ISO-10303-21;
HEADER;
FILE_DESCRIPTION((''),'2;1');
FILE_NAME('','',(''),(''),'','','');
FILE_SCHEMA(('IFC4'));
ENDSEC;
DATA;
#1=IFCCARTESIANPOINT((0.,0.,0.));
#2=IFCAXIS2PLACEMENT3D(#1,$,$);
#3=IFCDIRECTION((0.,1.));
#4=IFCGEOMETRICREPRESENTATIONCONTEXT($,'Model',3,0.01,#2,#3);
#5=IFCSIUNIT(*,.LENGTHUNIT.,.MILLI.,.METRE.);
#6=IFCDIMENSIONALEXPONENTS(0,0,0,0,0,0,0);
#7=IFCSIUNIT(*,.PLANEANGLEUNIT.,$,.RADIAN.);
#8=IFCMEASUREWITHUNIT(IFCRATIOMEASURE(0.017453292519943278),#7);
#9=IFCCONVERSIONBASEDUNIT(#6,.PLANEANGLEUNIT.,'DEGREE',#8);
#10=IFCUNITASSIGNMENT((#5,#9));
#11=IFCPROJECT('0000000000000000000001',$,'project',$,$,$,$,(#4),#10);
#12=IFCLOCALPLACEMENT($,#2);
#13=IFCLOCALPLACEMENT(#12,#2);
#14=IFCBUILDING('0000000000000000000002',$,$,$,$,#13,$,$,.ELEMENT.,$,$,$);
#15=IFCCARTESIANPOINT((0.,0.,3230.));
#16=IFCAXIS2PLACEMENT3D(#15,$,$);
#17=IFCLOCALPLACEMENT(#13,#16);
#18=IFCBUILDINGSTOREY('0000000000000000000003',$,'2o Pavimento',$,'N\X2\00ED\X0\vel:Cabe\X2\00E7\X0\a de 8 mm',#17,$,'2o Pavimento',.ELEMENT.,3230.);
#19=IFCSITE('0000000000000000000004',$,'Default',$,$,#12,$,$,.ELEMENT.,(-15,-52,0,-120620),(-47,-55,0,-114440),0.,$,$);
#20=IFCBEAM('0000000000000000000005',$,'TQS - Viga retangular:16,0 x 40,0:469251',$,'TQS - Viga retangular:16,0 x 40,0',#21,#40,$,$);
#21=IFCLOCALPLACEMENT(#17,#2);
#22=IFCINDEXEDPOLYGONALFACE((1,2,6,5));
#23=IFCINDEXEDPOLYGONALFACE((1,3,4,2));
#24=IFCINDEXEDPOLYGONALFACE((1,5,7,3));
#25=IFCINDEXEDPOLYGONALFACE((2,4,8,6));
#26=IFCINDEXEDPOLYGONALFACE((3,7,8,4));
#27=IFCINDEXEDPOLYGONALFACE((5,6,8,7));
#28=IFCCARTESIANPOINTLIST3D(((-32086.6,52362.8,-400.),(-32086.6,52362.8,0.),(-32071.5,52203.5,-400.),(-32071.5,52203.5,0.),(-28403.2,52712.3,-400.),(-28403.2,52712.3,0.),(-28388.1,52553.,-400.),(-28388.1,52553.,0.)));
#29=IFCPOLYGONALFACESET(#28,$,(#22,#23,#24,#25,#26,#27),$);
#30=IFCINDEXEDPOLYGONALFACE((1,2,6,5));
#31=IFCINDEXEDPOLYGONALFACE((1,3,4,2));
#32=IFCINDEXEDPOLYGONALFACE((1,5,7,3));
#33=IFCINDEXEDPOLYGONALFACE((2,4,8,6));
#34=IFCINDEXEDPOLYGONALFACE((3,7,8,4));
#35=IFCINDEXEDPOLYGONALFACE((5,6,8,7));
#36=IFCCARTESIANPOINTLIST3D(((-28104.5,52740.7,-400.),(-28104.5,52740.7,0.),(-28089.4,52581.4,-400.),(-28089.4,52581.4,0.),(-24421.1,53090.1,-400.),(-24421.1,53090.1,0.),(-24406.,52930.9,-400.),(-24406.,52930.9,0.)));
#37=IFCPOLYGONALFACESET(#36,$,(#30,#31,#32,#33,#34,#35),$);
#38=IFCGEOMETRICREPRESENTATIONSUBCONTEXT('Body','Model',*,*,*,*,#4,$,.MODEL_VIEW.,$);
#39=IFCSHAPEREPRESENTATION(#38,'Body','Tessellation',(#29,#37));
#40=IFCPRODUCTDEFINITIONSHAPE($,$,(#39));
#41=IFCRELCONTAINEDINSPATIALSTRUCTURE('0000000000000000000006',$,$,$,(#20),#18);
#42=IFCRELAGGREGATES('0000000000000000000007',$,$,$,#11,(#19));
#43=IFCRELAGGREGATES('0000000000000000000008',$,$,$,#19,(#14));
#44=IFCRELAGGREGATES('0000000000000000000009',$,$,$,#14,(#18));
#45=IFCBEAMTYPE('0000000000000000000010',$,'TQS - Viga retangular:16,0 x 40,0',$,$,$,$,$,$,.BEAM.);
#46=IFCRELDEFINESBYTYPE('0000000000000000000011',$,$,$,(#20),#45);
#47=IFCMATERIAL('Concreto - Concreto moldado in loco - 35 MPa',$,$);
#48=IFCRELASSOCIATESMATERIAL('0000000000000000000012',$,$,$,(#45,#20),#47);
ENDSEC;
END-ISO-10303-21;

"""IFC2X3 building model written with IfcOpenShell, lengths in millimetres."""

from ifc_helpers import new_model, entity, si_unit, converted_unit, direction, frame, frame_2d, origin, place, context, subcontext, project, spatial, rectangle, extrude, source, transform, mapped, material, type_object, type_shapes, element, save


model = new_model("IFC2X3")

# Units and contexts
model_context = context("Model", 3, precision=0.01, world=origin(), true_north=direction((0.0, 1.0)))
body_context = subcontext(model_context, "Body", "Model", "MODEL_VIEW")
ifc_project = project(units=[si_unit("LENGTHUNIT", "METRE", prefix="MILLI"), converted_unit("PLANEANGLEUNIT", "DEGREE", entity("IfcRatioMeasure", 0.017453292519943278), si_unit("PLANEANGLEUNIT", "RADIAN"), dimensions=[0, 0, 0, 0, 0, 0, 0])], contexts=[model_context])

# Site, building, storey
site_placement = place(None, origin())
site = spatial("IfcSite", under=ifc_project, at=site_placement, Name="Default", CompositionType="ELEMENT", RefLatitude=(-15, -52, 0, -120620), RefLongitude=(-47, -55, 0, -114440), RefElevation=0.0)
building_placement = place(site_placement, origin())
building = spatial("IfcBuilding", under=site, at=building_placement, CompositionType="ELEMENT")
storey_placement = place(building_placement, frame((0.0, 0.0, 3230.0)))
storey = spatial("IfcBuildingStorey", under=building, at=storey_placement, Name="2o Pavimento", ObjectType="Nível:Cabeça de 8 mm", LongName="2o Pavimento", CompositionType="ELEMENT", Elevation=3230.0)

# Shared definitions
ifc_material = material(Name="Concreto - Concreto moldado in loco - 35 MPa")

# Beam
beam_type_1 = type_object("IfcBeamType", Name="TQS - Viga retangular:16,0 x 40,0", PredefinedType="BEAM", material=ifc_material)
shared_shape_1 = source(origin(), body_context, "Body", "SweptSolid", [
    extrude(rectangle(XDim=400.0, YDim=160.0, at=frame_2d((0.0, 0.0), x_axis=(1.0, 0.0))), frame((-28395.6, 52632.7, 3030.0), z_axis=(-0.995529, -0.094456, 0.0), x_axis=(0.0, 0.0, -1.0)), (0.0, 0.0, 1.0), 3700.0),
    extrude(rectangle(XDim=400.0, YDim=160.0, at=frame_2d((0.0, 0.0), x_axis=(1.0, 0.0))), frame((-24413.5, 53010.5, 3030.0), z_axis=(-0.995529, -0.094456, 0.0), x_axis=(0.0, 0.0, -1.0)), (0.0, 0.0, 1.0), 3700.0),
])
type_shapes(beam_type_1, [shared_shape_1])
beam_1_placement = place(storey_placement, frame((0.0, 0.0, -3230.0)))
element("IfcBeam", 1, at=beam_1_placement, inside=storey, type_object=beam_type_1, material=ifc_material, Name="TQS - Viga retangular:16,0 x 40,0:469251", ObjectType="TQS - Viga retangular:16,0 x 40,0", context=body_context, shape_type="MappedRepresentation", body=[
    mapped(shared_shape_1, transform((0.0, 0.0, 0.0), scale=1.0)),
])

save(model, "model.ifc")
